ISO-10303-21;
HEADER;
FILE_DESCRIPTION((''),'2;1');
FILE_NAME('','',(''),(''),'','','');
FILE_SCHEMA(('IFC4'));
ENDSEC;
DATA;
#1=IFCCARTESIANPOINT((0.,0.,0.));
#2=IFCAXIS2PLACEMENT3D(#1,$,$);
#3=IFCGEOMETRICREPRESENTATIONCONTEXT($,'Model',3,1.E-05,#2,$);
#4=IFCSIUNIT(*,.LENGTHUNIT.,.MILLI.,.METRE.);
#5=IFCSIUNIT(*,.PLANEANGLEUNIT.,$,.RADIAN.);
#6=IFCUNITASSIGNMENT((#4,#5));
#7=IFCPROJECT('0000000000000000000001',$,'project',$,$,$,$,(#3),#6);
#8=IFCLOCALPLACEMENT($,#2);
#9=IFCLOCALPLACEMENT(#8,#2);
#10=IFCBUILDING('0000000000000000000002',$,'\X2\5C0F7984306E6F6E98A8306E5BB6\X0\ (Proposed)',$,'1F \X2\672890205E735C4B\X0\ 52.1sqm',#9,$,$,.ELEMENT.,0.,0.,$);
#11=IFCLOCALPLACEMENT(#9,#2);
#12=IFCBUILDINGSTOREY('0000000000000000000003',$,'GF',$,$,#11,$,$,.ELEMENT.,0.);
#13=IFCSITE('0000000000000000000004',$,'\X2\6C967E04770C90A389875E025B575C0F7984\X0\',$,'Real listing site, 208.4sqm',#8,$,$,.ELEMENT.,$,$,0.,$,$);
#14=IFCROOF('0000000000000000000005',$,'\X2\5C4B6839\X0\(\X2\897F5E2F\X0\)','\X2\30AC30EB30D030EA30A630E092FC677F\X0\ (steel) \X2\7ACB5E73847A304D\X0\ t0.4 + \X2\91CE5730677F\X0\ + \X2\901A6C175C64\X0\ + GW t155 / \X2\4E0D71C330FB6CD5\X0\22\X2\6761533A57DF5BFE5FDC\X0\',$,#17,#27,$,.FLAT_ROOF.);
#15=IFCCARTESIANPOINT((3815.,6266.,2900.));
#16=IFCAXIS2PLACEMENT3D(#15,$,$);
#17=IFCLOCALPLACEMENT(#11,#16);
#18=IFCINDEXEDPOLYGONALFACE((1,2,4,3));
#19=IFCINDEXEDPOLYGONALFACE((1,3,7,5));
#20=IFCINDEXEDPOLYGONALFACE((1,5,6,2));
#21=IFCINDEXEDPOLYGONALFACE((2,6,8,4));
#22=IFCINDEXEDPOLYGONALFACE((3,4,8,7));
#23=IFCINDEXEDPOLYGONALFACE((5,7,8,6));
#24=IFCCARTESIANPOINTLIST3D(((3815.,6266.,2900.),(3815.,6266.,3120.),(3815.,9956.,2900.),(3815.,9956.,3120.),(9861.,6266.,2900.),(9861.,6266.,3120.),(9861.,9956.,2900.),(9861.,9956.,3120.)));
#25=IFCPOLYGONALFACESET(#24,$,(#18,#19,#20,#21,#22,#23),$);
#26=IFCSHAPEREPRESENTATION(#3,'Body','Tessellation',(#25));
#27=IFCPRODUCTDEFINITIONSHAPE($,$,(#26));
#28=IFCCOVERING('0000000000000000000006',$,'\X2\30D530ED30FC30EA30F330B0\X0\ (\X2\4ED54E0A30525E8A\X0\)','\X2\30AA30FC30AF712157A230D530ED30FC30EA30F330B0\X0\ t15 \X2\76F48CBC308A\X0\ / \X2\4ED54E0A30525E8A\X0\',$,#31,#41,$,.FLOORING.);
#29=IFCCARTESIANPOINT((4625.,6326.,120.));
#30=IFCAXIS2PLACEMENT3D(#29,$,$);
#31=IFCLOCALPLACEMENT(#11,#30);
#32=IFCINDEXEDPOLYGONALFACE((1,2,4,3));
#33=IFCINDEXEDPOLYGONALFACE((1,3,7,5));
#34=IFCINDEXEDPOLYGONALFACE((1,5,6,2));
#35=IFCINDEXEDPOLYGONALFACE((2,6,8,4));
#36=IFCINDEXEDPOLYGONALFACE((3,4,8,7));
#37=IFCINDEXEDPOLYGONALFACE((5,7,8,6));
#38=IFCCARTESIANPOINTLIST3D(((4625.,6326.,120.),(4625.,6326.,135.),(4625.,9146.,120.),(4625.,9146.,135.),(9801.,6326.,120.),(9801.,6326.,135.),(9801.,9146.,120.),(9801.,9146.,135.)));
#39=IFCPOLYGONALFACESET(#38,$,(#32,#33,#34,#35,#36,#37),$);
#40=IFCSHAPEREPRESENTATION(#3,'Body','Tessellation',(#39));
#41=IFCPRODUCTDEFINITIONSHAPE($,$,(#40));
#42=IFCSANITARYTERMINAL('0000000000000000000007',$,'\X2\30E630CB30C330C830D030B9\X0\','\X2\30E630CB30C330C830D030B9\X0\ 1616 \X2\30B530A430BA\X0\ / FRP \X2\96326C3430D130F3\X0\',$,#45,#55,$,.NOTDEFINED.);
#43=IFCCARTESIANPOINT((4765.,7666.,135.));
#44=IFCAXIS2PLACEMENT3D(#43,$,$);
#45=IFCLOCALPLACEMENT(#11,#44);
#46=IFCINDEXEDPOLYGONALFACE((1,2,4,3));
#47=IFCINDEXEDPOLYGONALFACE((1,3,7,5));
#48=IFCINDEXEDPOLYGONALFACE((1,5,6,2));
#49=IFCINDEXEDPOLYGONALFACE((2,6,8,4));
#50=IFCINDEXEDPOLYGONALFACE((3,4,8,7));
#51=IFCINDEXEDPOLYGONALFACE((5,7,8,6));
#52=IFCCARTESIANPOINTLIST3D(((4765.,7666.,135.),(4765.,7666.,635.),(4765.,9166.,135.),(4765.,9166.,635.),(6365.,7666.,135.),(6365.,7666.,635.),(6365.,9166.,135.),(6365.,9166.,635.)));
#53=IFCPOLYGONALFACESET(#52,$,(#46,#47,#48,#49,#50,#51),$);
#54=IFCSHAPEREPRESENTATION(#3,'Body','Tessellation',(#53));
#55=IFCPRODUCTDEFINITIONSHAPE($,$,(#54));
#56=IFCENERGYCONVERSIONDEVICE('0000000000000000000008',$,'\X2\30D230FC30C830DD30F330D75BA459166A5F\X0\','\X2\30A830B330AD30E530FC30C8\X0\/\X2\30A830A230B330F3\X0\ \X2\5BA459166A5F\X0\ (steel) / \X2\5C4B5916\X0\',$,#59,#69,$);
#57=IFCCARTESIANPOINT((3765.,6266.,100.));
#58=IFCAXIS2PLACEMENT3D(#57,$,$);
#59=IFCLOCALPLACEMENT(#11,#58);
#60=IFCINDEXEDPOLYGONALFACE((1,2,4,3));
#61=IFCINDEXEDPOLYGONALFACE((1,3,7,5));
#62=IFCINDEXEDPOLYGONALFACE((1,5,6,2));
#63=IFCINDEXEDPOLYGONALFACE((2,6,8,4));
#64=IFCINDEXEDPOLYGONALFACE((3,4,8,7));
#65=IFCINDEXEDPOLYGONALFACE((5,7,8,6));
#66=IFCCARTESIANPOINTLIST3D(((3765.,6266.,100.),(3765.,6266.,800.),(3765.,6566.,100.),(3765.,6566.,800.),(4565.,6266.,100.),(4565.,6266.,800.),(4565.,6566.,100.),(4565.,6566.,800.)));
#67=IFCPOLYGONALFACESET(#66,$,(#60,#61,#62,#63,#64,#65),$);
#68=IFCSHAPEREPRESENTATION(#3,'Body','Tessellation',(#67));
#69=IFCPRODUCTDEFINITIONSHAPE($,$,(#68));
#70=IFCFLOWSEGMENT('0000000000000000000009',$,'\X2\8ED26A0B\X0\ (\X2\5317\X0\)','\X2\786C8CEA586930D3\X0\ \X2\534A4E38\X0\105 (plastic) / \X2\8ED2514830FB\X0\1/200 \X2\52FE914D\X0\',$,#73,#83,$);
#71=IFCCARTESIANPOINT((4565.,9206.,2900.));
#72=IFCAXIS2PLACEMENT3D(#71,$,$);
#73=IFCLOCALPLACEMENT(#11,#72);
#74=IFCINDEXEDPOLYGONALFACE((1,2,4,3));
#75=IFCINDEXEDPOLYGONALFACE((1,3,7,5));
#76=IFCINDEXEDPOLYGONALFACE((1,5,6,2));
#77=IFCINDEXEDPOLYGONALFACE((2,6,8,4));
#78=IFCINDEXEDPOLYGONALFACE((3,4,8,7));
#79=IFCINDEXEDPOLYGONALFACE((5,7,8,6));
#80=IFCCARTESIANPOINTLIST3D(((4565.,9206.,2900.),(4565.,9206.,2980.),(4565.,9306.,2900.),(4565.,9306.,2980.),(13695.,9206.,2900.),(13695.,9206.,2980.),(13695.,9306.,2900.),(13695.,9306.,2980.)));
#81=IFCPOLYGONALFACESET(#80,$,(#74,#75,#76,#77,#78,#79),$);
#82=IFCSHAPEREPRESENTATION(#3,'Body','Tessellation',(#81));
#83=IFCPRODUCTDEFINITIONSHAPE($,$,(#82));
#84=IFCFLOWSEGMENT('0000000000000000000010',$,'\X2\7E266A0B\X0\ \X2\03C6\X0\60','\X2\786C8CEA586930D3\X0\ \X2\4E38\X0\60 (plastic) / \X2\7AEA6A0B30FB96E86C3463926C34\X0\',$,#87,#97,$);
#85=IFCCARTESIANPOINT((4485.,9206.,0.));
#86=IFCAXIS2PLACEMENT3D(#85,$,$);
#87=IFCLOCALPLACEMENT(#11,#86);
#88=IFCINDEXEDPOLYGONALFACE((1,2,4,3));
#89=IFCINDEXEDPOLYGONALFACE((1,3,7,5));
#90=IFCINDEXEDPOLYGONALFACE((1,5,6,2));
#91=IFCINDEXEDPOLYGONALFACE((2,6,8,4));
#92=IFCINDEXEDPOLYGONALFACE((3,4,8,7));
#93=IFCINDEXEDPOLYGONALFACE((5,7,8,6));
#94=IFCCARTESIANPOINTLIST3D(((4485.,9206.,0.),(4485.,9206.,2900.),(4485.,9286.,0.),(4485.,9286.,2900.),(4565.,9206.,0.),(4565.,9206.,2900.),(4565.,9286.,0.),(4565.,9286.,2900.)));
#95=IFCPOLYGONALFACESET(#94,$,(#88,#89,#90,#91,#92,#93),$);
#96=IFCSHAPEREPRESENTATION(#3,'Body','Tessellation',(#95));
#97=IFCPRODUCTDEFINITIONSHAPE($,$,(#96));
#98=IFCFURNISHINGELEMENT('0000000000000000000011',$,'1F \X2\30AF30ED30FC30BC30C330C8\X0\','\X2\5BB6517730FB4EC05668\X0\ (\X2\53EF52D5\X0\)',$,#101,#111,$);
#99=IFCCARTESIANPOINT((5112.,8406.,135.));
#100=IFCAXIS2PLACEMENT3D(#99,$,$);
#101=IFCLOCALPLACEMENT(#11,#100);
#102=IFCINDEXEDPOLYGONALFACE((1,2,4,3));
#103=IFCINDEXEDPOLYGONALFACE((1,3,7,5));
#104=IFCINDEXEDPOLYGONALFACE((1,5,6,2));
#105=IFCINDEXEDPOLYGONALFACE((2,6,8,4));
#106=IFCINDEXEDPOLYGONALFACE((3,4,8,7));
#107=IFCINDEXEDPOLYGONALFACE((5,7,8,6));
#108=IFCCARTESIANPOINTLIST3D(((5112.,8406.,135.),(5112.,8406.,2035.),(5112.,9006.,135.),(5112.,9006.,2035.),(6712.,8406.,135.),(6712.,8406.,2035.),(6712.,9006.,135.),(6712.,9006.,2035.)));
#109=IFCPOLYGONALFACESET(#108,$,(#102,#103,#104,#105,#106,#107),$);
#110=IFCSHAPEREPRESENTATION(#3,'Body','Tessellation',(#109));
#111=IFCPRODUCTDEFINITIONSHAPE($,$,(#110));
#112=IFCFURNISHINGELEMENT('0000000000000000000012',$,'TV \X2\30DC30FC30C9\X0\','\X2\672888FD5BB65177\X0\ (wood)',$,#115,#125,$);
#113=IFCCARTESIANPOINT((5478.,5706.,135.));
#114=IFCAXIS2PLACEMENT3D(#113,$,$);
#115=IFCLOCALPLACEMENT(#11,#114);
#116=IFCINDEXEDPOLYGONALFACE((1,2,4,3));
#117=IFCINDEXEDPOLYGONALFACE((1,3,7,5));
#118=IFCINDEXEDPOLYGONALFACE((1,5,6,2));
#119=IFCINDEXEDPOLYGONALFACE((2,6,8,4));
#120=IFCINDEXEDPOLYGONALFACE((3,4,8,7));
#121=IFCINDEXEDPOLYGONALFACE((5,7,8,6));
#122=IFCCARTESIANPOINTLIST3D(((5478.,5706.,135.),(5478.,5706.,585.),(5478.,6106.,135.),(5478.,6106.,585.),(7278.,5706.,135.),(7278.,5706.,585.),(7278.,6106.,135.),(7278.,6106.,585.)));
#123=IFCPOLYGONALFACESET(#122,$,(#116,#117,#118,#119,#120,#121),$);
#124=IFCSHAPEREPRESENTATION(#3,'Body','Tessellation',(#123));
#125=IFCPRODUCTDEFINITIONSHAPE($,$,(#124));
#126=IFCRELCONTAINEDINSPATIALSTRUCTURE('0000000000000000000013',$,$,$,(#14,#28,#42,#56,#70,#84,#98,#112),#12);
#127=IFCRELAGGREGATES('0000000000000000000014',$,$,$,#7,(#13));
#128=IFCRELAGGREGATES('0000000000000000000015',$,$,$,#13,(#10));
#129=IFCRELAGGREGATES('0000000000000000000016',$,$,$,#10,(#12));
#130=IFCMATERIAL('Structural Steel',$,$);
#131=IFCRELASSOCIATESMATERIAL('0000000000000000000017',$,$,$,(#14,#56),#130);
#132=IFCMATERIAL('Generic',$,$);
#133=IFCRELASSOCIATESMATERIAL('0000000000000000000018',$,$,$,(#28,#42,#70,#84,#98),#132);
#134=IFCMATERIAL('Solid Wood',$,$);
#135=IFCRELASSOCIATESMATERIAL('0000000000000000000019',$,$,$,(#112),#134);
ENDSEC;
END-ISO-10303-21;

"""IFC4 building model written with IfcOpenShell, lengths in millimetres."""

from ifc_helpers import new_model, si_unit, frame, frame_2d, origin, place, context, project, spatial, rectangle, extrude, material, element, save


model = new_model("IFC4")

# Units and contexts
model_context = context("Model", 3, precision=1e-05, world=origin())
ifc_project = project(units=[si_unit("LENGTHUNIT", "METRE", prefix="MILLI"), si_unit("PLANEANGLEUNIT", "RADIAN")], contexts=[model_context])

# Site, building, storey
site_placement = place(None, origin())
site = spatial("IfcSite", under=ifc_project, at=site_placement, Name="沖縄県那覇市字小禄", ObjectType="Real listing site, 208.4sqm", CompositionType="ELEMENT", RefElevation=0.0)
building_placement = place(site_placement, origin())
building = spatial("IfcBuilding", under=site, at=building_placement, Name="小禄の潮風の家 (Proposed)", ObjectType="1F 木造平屋 52.1sqm", CompositionType="ELEMENT", ElevationOfRefHeight=0.0, ElevationOfTerrain=0.0)
storey_placement = place(building_placement, origin())
storey = spatial("IfcBuildingStorey", under=building, at=storey_placement, Name="GF", CompositionType="ELEMENT", Elevation=0.0)

# Shared definitions
ifc_material_1 = material(Name="Solid Wood")

# Roof
ifc_material_2 = material(Name="Structural Steel")
roof_placement = place(storey_placement, frame((3815.0, 6266.0, 2900.0)))
element("IfcRoof", 1, at=roof_placement, inside=storey, material=ifc_material_2, Name="屋根(西帯)", Description="ガルバリウム鋼板 (steel) 立平葺き t0.4 + 野地板 + 通気層 + GW t155 / 不燃・法22条区域対応", PredefinedType="FLAT_ROOF", context=model_context, shape_type="SweptSolid", body=[
    extrude(rectangle(XDim=6046.0, YDim=3690.0, at=frame_2d((3023.0, 1845.0))), frame((3815.0, 6266.0, 2900.0)), (0.0, 0.0, 1.0), 220.0),
])

# Covering
ifc_material_3 = material(Name="Generic")
covering_placement = place(storey_placement, frame((4625.0, 6326.0, 120.0)))
element("IfcCovering", 2, at=covering_placement, inside=storey, material=ifc_material_3, Name="フローリング (仕上げ床)", Description="オーク無垢フローリング t15 直貼り / 仕上げ床", PredefinedType="FLOORING", context=model_context, shape_type="SweptSolid", body=[
    extrude(rectangle(XDim=5176.0, YDim=2820.0, at=frame_2d((2588.0, 1410.0))), frame((4625.0, 6326.0, 120.0)), (0.0, 0.0, 1.0), 15.0),
])

# Sanitary terminal
sanitary_terminal_placement = place(storey_placement, frame((4765.0, 7666.0, 135.0)))
element("IfcSanitaryTerminal", 3, at=sanitary_terminal_placement, inside=storey, material=ifc_material_3, Name="ユニットバス", Description="ユニットバス 1616 サイズ / FRP 防水パン", PredefinedType="NOTDEFINED", context=model_context, shape_type="SweptSolid", body=[
    extrude(rectangle(XDim=1600.0, YDim=1500.0, at=frame_2d((800.0, 750.0))), frame((4765.0, 7666.0, 135.0)), (0.0, 0.0, 1.0), 500.0),
])

# Energy conversion device
energy_conversion_device_placement = place(storey_placement, frame((3765.0, 6266.0, 100.0)))
element("IfcEnergyConversionDevice", 4, at=energy_conversion_device_placement, inside=storey, material=ifc_material_2, Name="ヒートポンプ室外機", Description="エコキュート/エアコン 室外機 (steel) / 屋外", context=model_context, shape_type="SweptSolid", body=[
    extrude(rectangle(XDim=800.0, YDim=300.0, at=frame_2d((400.0, 150.0))), frame((3765.0, 6266.0, 100.0)), (0.0, 0.0, 1.0), 700.0),
])

# Flow segments
flow_segment_1_placement = place(storey_placement, frame((4565.0, 9206.0, 2900.0)))
element("IfcFlowSegment", 5, at=flow_segment_1_placement, inside=storey, material=ifc_material_3, Name="軒樋 (北)", Description="硬質塩ビ 半丸105 (plastic) / 軒先・1/200 勾配", context=model_context, shape_type="SweptSolid", body=[
    extrude(rectangle(XDim=9130.0, YDim=100.0, at=frame_2d((4565.0, 50.0))), frame((4565.0, 9206.0, 2900.0)), (0.0, 0.0, 1.0), 80.0),
])
flow_segment_2_placement = place(storey_placement, frame((4485.0, 9206.0, 0.0)))
element("IfcFlowSegment", 6, at=flow_segment_2_placement, inside=storey, material=ifc_material_3, Name="縦樋 φ60", Description="硬質塩ビ 丸60 (plastic) / 竪樋・雨水排水", context=model_context, shape_type="SweptSolid", body=[
    extrude(rectangle(XDim=80.0, YDim=80.0, at=frame_2d((40.0, 40.0))), frame((4485.0, 9206.0, 0.0)), (0.0, 0.0, 1.0), 2900.0),
])

# Furnishing elements
furnishing_1_placement = place(storey_placement, frame((5112.0, 8406.0, 135.0)))
element("IfcFurnishingElement", 7, at=furnishing_1_placement, inside=storey, material=ifc_material_3, Name="1F クローゼット", Description="家具・什器 (可動)", context=model_context, shape_type="SweptSolid", body=[
    extrude(rectangle(XDim=1600.0, YDim=600.0, at=frame_2d((800.0, 300.0))), frame((5112.0, 8406.0, 135.0)), (0.0, 0.0, 1.0), 1900.0),
])
furnishing_2_placement = place(storey_placement, frame((5478.0, 5706.0, 135.0)))
element("IfcFurnishingElement", 8, at=furnishing_2_placement, inside=storey, material=ifc_material_1, Name="TV ボード", Description="木製家具 (wood)", context=model_context, shape_type="SweptSolid", body=[
    extrude(rectangle(XDim=1800.0, YDim=400.0, at=frame_2d((900.0, 200.0))), frame((5478.0, 5706.0, 135.0)), (0.0, 0.0, 1.0), 450.0),
])

save(model, "model.ifc")
